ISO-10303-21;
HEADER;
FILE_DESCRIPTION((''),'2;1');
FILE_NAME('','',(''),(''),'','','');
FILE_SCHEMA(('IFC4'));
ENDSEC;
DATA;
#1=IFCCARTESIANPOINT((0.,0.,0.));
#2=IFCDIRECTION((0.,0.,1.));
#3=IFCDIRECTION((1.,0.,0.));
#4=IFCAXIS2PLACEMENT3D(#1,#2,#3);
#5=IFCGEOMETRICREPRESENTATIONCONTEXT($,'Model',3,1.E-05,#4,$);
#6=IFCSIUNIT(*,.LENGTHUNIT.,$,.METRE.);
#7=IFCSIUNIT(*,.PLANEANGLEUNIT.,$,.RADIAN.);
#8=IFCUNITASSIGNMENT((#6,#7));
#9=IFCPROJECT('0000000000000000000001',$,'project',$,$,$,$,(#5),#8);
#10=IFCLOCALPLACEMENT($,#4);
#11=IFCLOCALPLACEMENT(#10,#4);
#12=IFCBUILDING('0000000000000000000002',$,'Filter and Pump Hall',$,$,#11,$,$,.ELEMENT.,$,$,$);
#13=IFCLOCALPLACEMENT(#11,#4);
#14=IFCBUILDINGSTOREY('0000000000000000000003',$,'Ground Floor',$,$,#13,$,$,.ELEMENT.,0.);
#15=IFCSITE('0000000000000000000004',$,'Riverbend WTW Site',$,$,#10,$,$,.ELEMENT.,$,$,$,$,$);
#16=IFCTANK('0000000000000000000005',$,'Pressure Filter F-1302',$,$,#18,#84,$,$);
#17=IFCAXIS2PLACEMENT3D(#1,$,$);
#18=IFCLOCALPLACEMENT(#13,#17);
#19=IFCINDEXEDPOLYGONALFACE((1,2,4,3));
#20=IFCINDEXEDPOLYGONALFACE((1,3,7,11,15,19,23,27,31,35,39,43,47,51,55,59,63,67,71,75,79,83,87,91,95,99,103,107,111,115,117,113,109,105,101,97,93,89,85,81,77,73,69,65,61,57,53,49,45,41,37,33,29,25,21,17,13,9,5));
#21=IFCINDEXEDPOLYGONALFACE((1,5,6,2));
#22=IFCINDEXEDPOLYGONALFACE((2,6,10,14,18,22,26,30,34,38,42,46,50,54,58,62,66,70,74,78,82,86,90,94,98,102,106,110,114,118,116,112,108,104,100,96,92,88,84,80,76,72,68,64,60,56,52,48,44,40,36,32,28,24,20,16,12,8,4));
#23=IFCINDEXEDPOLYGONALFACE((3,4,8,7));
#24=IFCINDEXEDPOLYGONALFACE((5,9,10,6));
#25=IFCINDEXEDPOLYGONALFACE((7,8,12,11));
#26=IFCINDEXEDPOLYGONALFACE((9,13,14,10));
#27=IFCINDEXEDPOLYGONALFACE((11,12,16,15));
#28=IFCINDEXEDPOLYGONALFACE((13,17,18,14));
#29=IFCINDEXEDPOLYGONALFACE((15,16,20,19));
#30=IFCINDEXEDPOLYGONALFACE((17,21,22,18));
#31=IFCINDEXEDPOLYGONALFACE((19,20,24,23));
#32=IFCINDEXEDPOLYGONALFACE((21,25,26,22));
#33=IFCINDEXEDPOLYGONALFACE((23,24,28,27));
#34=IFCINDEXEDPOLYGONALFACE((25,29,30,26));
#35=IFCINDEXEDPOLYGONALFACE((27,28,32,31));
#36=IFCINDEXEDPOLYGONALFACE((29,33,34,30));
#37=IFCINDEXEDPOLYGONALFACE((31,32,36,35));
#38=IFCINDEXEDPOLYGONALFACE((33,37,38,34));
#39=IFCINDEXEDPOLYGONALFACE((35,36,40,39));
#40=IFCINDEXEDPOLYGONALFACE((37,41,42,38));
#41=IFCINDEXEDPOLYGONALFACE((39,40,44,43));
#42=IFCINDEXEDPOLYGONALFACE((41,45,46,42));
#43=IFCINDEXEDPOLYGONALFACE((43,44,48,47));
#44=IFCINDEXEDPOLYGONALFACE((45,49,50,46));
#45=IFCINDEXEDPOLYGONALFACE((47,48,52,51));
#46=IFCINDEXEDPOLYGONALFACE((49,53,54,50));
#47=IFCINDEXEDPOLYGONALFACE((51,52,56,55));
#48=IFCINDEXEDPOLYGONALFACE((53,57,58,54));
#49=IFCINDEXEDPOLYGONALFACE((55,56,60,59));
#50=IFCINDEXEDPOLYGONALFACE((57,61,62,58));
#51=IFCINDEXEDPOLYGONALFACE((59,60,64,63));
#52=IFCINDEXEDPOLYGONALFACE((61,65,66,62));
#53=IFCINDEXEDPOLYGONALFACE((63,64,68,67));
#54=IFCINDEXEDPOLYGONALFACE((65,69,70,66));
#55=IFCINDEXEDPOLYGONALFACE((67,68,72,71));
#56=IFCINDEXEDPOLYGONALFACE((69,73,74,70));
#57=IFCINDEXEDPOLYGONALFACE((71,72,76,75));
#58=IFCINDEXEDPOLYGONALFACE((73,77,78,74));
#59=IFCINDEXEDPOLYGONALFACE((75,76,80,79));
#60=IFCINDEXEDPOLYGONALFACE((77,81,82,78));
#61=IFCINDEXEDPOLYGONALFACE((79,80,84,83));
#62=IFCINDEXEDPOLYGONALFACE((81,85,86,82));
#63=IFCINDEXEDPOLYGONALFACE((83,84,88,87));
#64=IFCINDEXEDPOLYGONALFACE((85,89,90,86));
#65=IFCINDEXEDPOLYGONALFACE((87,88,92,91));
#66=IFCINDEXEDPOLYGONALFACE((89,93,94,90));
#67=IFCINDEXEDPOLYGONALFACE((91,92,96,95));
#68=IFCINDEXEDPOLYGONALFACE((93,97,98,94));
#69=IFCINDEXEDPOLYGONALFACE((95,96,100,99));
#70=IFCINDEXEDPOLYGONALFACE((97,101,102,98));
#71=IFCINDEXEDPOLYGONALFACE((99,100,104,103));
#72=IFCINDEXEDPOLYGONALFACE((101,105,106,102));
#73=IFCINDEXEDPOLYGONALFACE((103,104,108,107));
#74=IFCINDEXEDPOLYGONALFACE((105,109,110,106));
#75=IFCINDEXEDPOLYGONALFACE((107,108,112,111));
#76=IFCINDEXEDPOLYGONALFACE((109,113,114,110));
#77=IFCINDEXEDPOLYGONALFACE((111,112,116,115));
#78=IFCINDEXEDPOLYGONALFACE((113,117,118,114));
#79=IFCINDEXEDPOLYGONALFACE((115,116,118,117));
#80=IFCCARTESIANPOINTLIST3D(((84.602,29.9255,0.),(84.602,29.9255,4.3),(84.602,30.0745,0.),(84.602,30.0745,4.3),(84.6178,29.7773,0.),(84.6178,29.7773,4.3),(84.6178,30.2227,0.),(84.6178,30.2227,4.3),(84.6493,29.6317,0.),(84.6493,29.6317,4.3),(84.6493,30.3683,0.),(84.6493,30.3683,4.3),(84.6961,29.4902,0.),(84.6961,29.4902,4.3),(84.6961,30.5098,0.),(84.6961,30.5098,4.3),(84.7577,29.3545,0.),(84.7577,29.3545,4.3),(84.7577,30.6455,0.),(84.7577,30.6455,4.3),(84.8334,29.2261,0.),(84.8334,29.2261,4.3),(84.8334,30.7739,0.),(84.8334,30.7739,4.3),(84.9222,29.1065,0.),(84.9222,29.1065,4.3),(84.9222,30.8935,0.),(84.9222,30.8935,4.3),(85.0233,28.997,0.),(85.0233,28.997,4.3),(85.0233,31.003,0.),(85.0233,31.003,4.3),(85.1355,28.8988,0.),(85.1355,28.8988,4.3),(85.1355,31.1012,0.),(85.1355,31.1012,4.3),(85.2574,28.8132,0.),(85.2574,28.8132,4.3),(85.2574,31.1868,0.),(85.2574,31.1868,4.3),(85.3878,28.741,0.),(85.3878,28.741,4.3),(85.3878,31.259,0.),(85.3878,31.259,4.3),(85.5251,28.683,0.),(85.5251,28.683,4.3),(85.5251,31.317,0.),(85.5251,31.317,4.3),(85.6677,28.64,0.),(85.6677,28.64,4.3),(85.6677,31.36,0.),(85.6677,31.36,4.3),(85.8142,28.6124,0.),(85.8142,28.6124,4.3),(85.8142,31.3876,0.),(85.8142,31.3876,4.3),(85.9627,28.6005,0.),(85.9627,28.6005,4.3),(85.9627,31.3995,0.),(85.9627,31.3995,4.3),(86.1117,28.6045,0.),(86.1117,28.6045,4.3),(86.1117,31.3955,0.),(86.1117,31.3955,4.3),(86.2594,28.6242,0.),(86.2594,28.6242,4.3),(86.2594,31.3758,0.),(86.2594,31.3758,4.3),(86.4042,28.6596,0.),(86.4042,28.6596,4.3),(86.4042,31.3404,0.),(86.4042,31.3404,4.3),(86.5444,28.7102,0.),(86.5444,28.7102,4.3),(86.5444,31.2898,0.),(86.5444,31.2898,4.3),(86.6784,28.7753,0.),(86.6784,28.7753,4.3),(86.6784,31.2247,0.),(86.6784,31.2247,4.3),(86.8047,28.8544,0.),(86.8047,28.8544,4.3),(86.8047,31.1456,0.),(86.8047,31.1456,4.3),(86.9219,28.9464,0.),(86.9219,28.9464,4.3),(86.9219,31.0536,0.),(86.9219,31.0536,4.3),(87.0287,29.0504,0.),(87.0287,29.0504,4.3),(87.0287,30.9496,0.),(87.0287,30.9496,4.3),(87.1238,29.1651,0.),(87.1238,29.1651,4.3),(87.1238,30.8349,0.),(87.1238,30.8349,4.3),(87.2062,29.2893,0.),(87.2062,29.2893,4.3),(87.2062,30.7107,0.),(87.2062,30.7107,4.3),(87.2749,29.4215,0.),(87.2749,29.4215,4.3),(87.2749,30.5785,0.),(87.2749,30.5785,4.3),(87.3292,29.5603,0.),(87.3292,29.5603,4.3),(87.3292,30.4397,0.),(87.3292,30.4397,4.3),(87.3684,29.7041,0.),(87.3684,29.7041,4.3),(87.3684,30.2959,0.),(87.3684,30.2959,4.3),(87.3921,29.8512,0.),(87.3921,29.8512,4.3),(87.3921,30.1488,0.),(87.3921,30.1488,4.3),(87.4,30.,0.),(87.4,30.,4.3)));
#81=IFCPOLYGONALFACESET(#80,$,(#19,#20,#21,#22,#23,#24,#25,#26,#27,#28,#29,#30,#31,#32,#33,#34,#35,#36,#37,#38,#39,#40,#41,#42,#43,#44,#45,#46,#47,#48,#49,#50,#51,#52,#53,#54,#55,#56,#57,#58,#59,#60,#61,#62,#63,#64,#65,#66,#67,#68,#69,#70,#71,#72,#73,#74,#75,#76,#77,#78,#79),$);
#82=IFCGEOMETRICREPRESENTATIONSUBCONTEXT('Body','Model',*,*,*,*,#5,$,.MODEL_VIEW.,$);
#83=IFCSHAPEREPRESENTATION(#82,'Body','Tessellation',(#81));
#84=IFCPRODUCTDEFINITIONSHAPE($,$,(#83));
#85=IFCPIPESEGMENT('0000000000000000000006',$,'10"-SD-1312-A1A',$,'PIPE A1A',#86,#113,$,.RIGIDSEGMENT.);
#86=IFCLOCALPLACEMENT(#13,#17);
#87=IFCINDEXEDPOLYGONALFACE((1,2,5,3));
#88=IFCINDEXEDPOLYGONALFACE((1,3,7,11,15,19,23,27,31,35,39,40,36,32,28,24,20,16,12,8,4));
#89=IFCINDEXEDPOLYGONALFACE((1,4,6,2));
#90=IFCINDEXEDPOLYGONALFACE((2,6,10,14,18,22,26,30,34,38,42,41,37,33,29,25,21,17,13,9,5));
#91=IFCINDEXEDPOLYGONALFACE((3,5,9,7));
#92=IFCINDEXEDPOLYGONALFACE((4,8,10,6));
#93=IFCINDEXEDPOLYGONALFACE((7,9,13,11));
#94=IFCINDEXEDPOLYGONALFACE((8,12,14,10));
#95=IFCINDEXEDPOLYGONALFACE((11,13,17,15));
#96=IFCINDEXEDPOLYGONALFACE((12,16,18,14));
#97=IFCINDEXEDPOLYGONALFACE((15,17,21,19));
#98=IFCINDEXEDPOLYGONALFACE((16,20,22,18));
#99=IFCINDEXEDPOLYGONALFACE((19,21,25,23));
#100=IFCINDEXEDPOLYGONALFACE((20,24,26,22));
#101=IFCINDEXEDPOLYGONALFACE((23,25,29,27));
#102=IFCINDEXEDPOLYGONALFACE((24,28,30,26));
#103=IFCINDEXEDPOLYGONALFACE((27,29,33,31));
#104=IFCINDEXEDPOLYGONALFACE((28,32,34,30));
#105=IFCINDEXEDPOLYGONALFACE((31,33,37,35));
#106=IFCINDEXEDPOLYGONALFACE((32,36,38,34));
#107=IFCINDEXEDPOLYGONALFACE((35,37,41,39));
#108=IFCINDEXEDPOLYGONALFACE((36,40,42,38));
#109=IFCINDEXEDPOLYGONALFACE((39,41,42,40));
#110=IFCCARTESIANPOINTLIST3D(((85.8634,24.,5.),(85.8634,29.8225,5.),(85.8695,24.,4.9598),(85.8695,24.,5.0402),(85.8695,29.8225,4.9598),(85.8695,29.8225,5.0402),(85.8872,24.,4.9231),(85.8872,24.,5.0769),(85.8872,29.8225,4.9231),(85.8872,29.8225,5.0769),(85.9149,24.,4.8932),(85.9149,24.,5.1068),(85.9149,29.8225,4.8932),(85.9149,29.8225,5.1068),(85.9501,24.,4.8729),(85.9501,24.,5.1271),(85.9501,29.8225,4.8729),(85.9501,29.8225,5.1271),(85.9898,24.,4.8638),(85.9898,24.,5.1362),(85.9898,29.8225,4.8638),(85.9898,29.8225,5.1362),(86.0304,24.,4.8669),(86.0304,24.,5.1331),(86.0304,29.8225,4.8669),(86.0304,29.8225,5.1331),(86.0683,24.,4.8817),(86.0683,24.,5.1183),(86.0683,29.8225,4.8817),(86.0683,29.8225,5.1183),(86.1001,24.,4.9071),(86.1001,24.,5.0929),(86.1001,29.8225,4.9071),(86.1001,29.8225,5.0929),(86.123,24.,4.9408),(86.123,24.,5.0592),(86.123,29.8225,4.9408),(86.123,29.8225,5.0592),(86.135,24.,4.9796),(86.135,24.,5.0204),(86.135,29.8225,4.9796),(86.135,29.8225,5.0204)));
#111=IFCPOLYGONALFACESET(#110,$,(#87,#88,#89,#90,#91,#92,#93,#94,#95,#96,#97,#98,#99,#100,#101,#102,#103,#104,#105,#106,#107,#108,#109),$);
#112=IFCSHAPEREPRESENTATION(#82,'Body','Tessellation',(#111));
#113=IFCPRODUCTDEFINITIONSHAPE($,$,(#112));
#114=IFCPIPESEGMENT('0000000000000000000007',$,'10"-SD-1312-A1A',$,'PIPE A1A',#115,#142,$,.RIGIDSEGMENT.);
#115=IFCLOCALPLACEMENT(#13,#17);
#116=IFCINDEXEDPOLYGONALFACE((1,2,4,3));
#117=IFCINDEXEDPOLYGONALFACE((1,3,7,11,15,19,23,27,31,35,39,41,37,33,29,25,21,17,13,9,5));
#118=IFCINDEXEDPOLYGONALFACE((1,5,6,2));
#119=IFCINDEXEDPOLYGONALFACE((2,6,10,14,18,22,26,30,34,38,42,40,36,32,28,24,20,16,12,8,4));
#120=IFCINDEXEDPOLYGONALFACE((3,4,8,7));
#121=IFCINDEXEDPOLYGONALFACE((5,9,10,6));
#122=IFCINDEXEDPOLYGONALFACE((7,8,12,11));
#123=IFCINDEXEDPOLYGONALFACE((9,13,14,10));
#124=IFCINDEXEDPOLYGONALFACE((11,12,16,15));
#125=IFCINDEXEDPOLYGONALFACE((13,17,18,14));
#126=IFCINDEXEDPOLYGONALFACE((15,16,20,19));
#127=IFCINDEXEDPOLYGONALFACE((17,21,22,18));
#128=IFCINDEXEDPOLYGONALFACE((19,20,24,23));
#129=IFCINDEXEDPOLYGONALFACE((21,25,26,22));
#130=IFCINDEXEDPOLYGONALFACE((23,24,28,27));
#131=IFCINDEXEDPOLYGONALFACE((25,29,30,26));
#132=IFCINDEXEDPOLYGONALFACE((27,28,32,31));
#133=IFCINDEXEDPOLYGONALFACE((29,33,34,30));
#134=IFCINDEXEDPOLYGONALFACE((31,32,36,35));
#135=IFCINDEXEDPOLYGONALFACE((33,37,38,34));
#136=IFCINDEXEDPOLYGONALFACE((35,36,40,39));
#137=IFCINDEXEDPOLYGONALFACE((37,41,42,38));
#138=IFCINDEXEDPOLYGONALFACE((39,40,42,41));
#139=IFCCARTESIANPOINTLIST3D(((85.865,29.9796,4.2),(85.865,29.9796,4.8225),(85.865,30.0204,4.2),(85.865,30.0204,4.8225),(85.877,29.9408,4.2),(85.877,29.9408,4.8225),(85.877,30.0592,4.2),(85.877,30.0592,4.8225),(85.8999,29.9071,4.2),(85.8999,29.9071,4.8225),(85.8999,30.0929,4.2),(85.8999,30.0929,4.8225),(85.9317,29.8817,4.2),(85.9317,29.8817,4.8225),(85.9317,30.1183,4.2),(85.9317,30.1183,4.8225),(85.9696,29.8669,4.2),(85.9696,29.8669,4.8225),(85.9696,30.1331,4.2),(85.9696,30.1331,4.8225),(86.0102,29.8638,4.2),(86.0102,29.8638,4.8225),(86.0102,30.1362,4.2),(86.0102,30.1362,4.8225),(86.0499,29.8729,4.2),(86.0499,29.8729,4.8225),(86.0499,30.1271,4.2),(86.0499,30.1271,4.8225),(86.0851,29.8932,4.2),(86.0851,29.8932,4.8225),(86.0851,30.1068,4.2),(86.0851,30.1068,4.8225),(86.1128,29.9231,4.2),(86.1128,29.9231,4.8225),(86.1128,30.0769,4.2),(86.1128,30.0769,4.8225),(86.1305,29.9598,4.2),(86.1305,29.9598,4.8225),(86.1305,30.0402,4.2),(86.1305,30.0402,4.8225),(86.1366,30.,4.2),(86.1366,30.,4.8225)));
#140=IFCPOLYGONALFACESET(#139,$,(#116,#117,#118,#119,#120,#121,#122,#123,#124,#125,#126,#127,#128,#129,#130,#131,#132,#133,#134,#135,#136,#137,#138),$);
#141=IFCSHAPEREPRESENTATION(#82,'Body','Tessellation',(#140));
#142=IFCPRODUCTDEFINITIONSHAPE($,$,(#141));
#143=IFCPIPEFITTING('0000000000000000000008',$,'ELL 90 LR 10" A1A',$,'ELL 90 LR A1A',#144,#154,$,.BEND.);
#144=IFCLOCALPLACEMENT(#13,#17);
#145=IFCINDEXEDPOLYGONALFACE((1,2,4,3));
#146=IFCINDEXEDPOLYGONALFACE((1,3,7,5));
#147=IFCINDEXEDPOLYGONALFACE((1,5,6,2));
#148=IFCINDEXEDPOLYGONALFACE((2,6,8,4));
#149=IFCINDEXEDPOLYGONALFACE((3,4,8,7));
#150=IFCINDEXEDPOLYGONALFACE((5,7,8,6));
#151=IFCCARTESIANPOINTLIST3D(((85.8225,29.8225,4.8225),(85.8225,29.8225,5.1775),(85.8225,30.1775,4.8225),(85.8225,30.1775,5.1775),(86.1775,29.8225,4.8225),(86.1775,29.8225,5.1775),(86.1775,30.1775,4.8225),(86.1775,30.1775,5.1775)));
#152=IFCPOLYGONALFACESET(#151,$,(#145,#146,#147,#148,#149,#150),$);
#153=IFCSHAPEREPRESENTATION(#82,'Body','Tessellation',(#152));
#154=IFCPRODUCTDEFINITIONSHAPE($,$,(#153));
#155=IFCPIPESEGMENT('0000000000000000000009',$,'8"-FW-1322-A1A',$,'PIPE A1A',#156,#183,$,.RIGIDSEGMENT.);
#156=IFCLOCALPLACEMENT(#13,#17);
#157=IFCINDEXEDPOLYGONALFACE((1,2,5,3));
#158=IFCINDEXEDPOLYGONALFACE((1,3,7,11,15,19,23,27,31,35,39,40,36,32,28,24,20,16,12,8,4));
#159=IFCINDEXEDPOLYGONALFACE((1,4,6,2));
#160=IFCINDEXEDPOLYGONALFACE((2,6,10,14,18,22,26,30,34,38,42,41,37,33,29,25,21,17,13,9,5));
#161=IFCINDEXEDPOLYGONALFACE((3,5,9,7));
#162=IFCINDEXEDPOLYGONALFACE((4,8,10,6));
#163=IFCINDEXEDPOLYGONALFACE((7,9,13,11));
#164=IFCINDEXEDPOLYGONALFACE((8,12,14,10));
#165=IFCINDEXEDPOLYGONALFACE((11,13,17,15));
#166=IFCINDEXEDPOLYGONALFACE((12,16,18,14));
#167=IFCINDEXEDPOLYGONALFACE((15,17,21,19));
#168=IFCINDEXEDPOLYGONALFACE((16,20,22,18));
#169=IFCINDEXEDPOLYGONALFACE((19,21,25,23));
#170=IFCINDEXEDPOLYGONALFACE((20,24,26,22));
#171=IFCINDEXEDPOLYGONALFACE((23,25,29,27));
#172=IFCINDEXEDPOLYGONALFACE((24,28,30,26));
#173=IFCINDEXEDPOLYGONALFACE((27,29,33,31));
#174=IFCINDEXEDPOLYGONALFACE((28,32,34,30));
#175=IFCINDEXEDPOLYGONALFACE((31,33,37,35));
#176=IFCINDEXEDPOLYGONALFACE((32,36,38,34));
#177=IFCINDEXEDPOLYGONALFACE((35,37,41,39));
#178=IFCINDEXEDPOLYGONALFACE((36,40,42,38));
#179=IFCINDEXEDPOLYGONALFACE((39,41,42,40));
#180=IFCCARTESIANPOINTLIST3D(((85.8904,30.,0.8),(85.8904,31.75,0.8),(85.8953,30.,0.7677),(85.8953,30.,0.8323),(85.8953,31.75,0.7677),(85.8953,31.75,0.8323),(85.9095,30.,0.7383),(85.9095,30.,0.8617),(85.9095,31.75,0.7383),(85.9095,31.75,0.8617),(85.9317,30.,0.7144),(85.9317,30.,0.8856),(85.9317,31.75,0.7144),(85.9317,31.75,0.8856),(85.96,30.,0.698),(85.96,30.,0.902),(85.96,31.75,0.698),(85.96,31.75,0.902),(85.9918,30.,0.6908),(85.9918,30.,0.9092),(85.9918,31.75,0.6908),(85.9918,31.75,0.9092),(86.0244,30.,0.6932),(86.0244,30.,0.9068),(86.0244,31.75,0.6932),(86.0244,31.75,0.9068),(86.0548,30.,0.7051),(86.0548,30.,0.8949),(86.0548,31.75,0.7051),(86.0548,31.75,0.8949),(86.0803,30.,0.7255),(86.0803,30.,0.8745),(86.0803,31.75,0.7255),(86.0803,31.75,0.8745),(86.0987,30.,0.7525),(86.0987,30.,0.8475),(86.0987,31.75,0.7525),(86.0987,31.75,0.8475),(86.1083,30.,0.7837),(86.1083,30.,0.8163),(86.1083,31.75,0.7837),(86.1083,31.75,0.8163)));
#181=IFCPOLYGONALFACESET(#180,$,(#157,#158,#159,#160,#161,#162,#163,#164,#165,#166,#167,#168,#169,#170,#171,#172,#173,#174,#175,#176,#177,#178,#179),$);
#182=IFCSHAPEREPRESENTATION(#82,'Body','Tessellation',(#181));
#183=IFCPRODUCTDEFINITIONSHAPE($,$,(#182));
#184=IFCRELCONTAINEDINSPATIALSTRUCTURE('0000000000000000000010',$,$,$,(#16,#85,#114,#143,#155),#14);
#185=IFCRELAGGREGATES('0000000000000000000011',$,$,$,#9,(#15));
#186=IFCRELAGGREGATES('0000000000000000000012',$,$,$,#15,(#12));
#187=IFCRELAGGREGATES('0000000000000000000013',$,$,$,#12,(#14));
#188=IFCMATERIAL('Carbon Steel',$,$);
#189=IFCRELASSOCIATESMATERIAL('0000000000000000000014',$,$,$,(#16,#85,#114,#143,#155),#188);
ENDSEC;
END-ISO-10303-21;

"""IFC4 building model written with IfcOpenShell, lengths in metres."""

from ifc_helpers import new_model, si_unit, frame, origin_with_axes, origin_2d, place, context, subcontext, project, spatial, rectangle, circle, extrude, material, element, save


model = new_model("IFC4")

# Units and contexts
model_context = context("Model", 3, precision=1e-05, world=origin_with_axes())
body_context = subcontext(model_context, "Body", "Model", "MODEL_VIEW")
ifc_project = project(units=[si_unit("LENGTHUNIT", "METRE"), si_unit("PLANEANGLEUNIT", "RADIAN")], contexts=[model_context])

# Site, building, storey
site_placement = place(None, origin_with_axes())
site = spatial("IfcSite", under=ifc_project, at=site_placement, Name="Riverbend WTW Site", CompositionType="ELEMENT")
building_placement = place(site_placement, origin_with_axes())
building = spatial("IfcBuilding", under=site, at=building_placement, Name="Filter and Pump Hall", CompositionType="ELEMENT")
storey_placement = place(building_placement, origin_with_axes())
storey = spatial("IfcBuildingStorey", under=building, at=storey_placement, Name="Ground Floor", CompositionType="ELEMENT", Elevation=0.0)

# Shared definitions
ifc_material_1 = material(Name="Carbon Steel")

# Tank
tank_placement = place(None, frame((86.0, 30.0, 0.0), z_axis=(0.0, 0.0, 1.0), x_axis=(1.0, 0.0, 0.0)))
element("IfcTank", 1, at=tank_placement, inside=storey, material=ifc_material_1, Name="Pressure Filter F-1302", context=body_context, shape_type="SweptSolid", body=[
    extrude(circle(Radius=1.4, at=origin_2d()), origin_with_axes(), (0.0, 0.0, 1.0), 4.3),
])

# Pipe segments
pipe_segment_1_placement = place(None, frame((86.0, 24.0, 5.0), z_axis=(0.0, 0.0, 1.0), x_axis=(1.0, 0.0, 0.0)))
element("IfcPipeSegment", 2, at=pipe_segment_1_placement, inside=storey, material=ifc_material_1, Name="10\"-SD-1312-A1A", ObjectType="PIPE A1A", PredefinedType="RIGIDSEGMENT", context=body_context, shape_type="SweptSolid", body=[
    extrude(circle(Radius=0.1366, at=origin_2d()), frame((0.0, 0.0, 0.0), z_axis=(0.0, 1.0, 0.0), x_axis=(-1.0, 0.0, 0.0)), (0.0, 0.0, 1.0), 5.8225),
])
pipe_segment_2_placement = place(None, frame((86.0, 30.0, 4.8225), z_axis=(0.0, 0.0, 1.0), x_axis=(1.0, 0.0, 0.0)))
element("IfcPipeSegment", 3, at=pipe_segment_2_placement, inside=storey, material=ifc_material_1, Name="10\"-SD-1312-A1A", ObjectType="PIPE A1A", PredefinedType="RIGIDSEGMENT", context=body_context, shape_type="SweptSolid", body=[
    extrude(circle(Radius=0.1366, at=origin_2d()), frame((0.0, 0.0, 0.0), z_axis=(0.0, 0.0, -1.0), x_axis=(1.0, 0.0, 0.0)), (0.0, 0.0, 1.0), 0.6225),
])

# Pipe fitting
pipe_fitting_placement = place(None, frame((86.0, 30.0, 5.0), z_axis=(0.0, 0.0, 1.0), x_axis=(1.0, 0.0, 0.0)))
element("IfcPipeFitting", 4, at=pipe_fitting_placement, inside=storey, material=ifc_material_1, Name="ELL 90 LR 10\" A1A", ObjectType="ELL 90 LR A1A", PredefinedType="BEND", context=body_context, shape_type="SweptSolid", body=[
    extrude(rectangle(XDim=0.355, YDim=0.355, at=origin_2d()), frame((0.0, 0.0, -0.1775), z_axis=(0.0, 0.0, 1.0), x_axis=(1.0, 0.0, 0.0)), (0.0, 0.0, 1.0), 0.355),
])

# Pipe segment
pipe_segment_3_placement = place(None, frame((86.0, 30.0, 0.8), z_axis=(0.0, 0.0, 1.0), x_axis=(1.0, 0.0, 0.0)))
element("IfcPipeSegment", 5, at=pipe_segment_3_placement, inside=storey, material=ifc_material_1, Name="8\"-FW-1322-A1A", ObjectType="PIPE A1A", PredefinedType="RIGIDSEGMENT", context=body_context, shape_type="SweptSolid", body=[
    extrude(circle(Radius=0.1095, at=origin_2d()), frame((0.0, 0.0, 0.0), z_axis=(0.0, 1.0, 0.0), x_axis=(-1.0, 0.0, 0.0)), (0.0, 0.0, 1.0), 1.75),
])

save(model, "model.ifc")
